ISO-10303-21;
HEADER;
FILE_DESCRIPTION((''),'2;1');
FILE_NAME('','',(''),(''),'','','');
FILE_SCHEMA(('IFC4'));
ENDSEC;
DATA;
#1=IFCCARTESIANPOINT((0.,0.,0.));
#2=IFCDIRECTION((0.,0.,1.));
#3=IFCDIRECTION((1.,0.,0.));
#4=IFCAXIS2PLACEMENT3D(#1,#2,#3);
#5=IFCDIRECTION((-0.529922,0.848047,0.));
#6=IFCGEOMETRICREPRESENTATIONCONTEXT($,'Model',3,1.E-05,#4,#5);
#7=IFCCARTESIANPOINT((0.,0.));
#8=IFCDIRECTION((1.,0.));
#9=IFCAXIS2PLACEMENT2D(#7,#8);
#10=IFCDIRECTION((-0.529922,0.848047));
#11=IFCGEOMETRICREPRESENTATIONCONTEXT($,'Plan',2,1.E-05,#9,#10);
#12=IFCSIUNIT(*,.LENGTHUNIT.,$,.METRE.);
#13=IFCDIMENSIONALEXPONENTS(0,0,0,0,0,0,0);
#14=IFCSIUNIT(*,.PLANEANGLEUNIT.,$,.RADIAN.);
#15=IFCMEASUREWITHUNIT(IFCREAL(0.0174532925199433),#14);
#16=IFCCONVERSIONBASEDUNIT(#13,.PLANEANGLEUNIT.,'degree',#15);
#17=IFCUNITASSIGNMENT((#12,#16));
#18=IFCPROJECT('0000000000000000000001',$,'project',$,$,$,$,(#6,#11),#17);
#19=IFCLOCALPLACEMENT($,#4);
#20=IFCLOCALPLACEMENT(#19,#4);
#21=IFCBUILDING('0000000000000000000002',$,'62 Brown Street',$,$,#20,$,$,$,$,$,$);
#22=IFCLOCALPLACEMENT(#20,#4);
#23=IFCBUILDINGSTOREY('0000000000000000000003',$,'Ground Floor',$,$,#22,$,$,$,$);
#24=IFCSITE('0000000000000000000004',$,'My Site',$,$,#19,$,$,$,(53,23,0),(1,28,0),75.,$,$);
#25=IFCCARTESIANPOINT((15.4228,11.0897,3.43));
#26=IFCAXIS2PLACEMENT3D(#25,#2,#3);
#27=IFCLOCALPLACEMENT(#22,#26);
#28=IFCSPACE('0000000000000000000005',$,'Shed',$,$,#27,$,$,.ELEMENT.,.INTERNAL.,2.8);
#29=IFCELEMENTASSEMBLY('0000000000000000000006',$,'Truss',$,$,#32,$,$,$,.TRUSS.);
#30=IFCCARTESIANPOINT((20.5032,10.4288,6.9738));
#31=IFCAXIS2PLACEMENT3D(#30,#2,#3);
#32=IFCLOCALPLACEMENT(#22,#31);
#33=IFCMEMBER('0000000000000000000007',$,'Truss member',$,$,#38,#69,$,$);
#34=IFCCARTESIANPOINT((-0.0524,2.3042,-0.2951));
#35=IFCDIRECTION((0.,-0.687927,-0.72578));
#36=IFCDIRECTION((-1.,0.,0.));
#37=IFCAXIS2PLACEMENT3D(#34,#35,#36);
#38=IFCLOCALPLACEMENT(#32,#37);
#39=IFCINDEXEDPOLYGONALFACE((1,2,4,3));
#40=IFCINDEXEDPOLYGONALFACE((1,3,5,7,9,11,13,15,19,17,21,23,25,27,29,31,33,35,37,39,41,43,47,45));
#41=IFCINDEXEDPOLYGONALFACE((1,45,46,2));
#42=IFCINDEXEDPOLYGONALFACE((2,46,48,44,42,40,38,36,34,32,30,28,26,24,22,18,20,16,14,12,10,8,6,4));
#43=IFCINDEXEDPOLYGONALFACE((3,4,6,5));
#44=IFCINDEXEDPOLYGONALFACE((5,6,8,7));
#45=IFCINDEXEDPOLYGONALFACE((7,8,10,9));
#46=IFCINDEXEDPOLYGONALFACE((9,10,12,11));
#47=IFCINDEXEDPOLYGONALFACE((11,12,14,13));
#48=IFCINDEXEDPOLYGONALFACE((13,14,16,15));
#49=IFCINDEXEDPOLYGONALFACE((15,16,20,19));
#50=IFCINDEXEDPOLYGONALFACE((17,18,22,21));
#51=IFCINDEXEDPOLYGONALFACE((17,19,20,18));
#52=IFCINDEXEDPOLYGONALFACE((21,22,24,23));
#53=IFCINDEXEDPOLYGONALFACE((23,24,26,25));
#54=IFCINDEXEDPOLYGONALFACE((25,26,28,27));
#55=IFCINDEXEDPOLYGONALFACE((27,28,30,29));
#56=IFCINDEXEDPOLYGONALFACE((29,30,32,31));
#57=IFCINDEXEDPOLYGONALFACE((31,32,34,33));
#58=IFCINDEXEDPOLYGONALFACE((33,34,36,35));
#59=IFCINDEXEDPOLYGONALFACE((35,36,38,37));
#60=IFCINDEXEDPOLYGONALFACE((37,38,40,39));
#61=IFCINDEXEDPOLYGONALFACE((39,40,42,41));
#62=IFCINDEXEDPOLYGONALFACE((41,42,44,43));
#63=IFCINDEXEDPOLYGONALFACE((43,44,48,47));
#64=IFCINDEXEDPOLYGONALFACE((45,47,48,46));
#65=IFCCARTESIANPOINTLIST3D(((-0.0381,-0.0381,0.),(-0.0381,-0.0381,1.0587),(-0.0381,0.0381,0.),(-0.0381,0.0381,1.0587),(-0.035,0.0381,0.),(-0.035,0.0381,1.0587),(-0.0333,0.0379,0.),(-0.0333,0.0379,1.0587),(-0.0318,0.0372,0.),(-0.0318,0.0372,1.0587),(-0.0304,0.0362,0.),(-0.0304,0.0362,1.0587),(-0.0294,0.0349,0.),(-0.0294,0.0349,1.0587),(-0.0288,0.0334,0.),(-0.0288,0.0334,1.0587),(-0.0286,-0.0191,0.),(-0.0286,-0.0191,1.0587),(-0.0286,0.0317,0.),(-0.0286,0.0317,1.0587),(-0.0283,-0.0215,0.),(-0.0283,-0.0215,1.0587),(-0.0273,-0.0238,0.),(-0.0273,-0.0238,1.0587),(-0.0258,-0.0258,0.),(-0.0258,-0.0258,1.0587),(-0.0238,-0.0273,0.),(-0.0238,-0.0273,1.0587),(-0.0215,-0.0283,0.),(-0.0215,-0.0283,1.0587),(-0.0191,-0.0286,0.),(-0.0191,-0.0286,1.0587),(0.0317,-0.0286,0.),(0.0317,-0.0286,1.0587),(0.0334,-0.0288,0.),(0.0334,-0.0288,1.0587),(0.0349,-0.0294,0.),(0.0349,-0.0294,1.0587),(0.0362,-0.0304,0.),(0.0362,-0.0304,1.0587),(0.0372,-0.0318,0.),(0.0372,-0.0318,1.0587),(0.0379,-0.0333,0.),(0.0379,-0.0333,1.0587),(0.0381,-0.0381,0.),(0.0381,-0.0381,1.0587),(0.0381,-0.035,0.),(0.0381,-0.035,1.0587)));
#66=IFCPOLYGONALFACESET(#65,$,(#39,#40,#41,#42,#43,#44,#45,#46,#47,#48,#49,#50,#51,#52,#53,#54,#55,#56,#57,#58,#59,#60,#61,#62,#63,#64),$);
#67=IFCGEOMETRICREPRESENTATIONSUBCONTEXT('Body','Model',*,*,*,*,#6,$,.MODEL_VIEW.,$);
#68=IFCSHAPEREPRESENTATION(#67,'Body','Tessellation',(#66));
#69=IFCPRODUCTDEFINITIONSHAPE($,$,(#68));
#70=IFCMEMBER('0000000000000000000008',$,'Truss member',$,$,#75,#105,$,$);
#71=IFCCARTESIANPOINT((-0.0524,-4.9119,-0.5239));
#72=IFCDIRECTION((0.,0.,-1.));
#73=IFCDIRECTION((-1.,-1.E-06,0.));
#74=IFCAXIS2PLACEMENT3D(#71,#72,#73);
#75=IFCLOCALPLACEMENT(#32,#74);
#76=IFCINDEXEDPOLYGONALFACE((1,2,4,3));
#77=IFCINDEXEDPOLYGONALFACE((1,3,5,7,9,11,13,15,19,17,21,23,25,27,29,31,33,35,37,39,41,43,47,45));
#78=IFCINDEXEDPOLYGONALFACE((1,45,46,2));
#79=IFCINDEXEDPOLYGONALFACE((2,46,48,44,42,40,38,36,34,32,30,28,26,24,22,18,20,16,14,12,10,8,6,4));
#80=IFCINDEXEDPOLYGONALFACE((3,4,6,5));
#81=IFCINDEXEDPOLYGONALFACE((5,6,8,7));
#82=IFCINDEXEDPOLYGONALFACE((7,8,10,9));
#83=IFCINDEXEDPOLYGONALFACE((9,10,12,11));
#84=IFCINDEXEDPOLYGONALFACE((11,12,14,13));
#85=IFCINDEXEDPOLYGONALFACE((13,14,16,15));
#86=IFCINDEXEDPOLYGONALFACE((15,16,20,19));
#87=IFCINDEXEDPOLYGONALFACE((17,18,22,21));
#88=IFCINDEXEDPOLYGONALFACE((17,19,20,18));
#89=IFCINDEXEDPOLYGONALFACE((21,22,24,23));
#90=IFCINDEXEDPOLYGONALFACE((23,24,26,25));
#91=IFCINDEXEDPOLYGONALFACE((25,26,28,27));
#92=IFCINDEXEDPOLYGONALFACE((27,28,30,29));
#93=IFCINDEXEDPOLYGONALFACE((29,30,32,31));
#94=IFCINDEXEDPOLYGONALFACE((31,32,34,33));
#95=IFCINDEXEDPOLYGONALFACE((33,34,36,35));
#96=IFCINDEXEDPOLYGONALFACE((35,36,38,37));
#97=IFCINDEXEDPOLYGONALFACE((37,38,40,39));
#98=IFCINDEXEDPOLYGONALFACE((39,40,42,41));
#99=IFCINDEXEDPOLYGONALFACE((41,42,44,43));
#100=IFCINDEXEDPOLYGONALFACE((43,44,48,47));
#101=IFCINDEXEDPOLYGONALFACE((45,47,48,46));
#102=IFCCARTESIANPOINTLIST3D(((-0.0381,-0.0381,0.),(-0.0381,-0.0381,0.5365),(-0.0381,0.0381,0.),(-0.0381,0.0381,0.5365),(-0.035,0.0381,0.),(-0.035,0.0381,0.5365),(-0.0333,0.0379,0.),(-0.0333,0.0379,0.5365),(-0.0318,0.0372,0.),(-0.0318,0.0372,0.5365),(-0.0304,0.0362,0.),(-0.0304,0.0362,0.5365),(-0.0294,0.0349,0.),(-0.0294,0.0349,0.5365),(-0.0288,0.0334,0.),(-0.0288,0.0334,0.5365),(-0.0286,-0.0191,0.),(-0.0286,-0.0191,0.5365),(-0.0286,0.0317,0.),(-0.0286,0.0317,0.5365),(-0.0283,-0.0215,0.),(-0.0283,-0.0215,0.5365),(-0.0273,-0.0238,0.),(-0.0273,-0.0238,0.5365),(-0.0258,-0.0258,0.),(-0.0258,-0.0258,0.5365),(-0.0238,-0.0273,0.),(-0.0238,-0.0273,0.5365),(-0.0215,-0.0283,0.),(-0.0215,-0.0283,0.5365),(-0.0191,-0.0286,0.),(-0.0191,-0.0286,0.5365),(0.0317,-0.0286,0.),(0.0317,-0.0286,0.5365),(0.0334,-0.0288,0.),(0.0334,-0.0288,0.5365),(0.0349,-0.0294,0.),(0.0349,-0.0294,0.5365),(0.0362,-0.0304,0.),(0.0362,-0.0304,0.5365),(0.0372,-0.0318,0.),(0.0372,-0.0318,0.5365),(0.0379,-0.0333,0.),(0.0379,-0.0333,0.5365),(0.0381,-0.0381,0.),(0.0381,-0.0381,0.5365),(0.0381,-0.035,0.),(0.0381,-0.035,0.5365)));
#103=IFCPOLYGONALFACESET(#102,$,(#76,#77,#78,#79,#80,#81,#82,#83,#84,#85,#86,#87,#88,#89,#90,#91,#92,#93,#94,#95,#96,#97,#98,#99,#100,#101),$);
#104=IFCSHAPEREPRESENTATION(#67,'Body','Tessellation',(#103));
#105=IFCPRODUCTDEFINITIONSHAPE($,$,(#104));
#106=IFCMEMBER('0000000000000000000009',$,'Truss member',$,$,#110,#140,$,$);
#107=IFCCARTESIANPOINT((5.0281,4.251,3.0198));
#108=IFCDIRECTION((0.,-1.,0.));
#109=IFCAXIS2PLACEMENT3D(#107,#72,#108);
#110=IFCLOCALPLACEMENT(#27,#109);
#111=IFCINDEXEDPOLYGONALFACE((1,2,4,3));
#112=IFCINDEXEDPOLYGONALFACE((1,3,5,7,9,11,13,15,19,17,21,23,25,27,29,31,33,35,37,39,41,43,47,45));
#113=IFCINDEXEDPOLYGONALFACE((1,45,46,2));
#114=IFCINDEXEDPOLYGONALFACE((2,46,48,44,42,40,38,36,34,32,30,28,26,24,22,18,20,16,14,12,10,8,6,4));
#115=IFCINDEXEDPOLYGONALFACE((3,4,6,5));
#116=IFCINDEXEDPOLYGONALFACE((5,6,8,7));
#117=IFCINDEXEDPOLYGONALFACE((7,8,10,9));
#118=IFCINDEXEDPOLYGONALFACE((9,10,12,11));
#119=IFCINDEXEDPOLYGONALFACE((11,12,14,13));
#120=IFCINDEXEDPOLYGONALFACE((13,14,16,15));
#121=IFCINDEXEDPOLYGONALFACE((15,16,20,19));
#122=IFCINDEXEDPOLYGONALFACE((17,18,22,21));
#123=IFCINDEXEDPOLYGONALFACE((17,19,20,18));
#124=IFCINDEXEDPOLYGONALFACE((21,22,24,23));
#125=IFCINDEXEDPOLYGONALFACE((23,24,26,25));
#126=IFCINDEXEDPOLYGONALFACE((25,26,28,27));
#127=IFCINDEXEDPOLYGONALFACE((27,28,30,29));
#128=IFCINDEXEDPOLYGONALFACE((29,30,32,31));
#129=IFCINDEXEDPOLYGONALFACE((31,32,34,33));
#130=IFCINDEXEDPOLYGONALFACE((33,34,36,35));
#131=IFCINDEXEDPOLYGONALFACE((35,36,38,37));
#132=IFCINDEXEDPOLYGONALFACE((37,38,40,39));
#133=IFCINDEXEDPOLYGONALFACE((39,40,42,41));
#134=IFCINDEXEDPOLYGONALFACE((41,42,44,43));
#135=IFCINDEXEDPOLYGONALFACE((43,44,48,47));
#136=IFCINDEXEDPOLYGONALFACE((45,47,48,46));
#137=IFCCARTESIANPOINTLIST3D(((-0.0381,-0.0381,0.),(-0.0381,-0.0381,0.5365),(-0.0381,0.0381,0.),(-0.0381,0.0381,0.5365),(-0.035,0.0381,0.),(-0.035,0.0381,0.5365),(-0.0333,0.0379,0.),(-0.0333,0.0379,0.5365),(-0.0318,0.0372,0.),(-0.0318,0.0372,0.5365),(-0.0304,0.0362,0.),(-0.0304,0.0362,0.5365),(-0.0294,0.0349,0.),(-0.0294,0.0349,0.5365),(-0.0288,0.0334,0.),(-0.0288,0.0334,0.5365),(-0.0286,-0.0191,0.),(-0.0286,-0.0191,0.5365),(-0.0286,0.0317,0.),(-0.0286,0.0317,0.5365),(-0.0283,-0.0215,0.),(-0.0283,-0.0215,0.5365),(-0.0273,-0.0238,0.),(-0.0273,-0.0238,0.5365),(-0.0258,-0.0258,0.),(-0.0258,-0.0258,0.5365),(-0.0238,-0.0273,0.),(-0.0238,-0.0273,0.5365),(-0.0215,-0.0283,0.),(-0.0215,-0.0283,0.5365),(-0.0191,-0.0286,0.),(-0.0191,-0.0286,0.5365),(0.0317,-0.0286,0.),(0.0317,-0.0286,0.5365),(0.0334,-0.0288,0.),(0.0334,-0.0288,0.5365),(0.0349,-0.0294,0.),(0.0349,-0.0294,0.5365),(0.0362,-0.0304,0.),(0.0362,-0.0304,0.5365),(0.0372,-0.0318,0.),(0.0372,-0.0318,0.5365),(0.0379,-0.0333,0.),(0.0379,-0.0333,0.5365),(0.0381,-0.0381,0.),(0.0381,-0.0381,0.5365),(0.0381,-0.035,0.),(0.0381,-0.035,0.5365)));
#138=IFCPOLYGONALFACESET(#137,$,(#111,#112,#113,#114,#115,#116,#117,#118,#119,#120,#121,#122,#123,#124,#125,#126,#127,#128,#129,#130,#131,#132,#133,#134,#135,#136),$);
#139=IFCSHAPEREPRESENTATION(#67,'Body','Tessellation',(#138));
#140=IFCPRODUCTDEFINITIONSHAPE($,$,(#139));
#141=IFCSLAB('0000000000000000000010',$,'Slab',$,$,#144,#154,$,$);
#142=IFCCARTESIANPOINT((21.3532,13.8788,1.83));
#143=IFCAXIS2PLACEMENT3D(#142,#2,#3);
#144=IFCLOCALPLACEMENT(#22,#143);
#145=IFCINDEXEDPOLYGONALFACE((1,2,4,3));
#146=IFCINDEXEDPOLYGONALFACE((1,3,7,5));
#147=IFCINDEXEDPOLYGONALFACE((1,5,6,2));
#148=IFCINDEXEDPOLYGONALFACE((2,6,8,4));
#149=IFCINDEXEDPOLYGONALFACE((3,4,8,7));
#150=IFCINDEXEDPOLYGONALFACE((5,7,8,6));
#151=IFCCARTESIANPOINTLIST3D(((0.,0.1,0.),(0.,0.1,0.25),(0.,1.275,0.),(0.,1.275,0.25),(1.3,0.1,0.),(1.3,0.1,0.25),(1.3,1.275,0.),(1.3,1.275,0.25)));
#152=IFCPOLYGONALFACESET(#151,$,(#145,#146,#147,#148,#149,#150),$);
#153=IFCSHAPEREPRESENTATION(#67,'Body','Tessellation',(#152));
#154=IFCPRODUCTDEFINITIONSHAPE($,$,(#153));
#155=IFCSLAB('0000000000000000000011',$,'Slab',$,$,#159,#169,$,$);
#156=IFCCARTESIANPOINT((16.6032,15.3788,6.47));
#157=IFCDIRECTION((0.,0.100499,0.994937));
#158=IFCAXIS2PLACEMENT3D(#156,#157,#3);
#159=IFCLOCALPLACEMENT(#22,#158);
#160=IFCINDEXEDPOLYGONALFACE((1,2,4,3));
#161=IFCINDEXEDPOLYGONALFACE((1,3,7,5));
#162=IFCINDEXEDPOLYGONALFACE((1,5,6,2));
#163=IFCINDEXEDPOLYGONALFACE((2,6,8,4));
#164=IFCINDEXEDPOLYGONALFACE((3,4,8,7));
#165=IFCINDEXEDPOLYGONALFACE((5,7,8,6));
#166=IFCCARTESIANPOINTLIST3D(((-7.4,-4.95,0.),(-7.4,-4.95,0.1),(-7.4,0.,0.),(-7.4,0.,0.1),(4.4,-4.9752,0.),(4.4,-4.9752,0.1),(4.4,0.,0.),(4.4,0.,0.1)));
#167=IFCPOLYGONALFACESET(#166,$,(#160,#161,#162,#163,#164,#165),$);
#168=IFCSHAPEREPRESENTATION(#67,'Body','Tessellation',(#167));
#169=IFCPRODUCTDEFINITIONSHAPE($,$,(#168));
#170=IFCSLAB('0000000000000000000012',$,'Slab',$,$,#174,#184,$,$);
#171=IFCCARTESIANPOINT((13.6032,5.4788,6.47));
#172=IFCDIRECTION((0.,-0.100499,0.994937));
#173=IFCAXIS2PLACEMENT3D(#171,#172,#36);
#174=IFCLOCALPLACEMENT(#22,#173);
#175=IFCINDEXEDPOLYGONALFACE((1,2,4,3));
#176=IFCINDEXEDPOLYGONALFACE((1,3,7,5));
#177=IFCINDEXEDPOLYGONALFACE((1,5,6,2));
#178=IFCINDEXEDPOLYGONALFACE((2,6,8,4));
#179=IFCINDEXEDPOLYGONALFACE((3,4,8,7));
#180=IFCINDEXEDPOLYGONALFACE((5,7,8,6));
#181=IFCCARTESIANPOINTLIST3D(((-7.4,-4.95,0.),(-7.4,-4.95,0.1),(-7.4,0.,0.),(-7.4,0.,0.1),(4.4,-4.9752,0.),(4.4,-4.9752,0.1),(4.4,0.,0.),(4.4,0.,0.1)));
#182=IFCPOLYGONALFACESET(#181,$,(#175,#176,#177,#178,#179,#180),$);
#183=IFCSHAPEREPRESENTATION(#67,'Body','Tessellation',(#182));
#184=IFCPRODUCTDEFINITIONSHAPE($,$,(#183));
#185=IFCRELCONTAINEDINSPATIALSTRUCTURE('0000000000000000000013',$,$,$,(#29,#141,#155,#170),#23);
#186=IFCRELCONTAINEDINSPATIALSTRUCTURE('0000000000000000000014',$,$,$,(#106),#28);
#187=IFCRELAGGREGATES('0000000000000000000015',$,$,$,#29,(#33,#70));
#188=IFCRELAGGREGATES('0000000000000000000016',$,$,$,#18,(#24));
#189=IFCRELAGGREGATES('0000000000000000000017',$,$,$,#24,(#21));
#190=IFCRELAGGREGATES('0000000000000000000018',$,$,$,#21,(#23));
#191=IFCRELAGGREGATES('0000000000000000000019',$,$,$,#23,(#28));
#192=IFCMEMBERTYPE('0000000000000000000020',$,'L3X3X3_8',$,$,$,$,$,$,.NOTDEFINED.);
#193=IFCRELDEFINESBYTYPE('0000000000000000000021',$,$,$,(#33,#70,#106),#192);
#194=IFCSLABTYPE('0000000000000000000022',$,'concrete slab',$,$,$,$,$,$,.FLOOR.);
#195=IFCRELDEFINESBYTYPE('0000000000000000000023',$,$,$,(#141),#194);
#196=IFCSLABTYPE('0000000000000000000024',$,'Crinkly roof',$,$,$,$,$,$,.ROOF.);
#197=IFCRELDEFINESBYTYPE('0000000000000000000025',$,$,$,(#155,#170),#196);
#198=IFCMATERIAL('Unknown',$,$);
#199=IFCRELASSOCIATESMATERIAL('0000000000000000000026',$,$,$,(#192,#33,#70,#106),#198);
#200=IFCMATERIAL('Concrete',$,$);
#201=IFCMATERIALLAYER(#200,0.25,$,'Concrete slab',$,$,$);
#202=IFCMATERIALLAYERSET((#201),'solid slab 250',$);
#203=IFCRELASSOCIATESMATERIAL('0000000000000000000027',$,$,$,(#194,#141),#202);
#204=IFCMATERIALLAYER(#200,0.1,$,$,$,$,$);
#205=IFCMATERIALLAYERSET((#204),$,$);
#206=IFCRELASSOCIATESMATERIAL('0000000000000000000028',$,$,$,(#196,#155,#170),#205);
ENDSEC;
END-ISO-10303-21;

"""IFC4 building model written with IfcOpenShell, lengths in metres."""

from ifc_helpers import new_model, entity, si_unit, converted_unit, direction, frame, origin_with_axes, origin_2d_with_axis, place, context, subcontext, project, spatial, indexed_curve, l_section, outline, extrude, material, layer, layer_set, layer_usage, material_profile, profile_set, profile_usage, type_object, element, aggregate, save


model = new_model("IFC4")

# Units and contexts
model_context = context("Model", 3, precision=1e-05, world=origin_with_axes(), true_north=direction((-0.529922, 0.848047, 0.0)))
plan_context = context("Plan", 2, precision=1e-05, world=origin_2d_with_axis(), true_north=direction((-0.529922, 0.848047)))
body_context_1 = subcontext(model_context, "Body", "Model", "MODEL_VIEW")
ifc_project = project(units=[si_unit("LENGTHUNIT", "METRE"), converted_unit("PLANEANGLEUNIT", "degree", entity("IfcReal", 0.0174532925199433), si_unit("PLANEANGLEUNIT", "RADIAN"), dimensions=[0, 0, 0, 0, 0, 0, 0])], contexts=[model_context, plan_context])

# Site, building, storey
site_placement = place(None, origin_with_axes())
site = spatial("IfcSite", under=ifc_project, at=site_placement, Name="My Site", RefLatitude=(53, 23, 0), RefLongitude=(1, 28, 0), RefElevation=75.0)
building_placement = place(site_placement, origin_with_axes())
building = spatial("IfcBuilding", under=site, at=building_placement, Name="62 Brown Street")
storey_placement = place(building_placement, origin_with_axes())
storey = spatial("IfcBuildingStorey", under=building, at=storey_placement, Name="Ground Floor")

# Shared definitions
ifc_material_1 = material(Name="Concrete")

# Element assembly, members
assembly_placement = place(storey_placement, frame((20.5032, 10.4288, 6.9738), z_axis=(0.0, 0.0, 1.0), x_axis=(1.0, 0.0, 0.0)))
assembly = element("IfcElementAssembly", 1, at=assembly_placement, inside=storey, Name="Truss", PredefinedType="TRUSS")
ifc_material_2 = material(Name="Unknown")
ifc_material_profile_1 = material_profile(ifc_material_2, l_section(Depth=0.0762, Width=0.0762, Thickness=0.0095, FilletRadius=0.0095, EdgeRadius=0.0064))
ifc_profile_set_1 = profile_set([ifc_material_profile_1])
member_type_1 = type_object("IfcMemberType", Name="L3X3X3_8", PredefinedType="NOTDEFINED", material=ifc_profile_set_1)
ifc_profile_usage_1 = profile_usage(ifc_profile_set_1, cardinal=5)
member_1_placement = place(assembly_placement, frame((-0.0524, 2.3042, -0.2951), z_axis=(0.0, -0.687927, -0.72578), x_axis=(-1.0, 0.0, 0.0)))
member_1 = element("IfcMember", 2, at=member_1_placement, type_object=member_type_1, material=ifc_profile_usage_1, Name="Truss member", context=body_context_1, shape_type="SweptSolid", body=[
    extrude(l_section(Depth=0.0762, Width=0.0762, Thickness=0.0095, FilletRadius=0.0095, EdgeRadius=0.0064), origin_with_axes(), (0.0, 0.0, 1.0), 1.0587),
])
ifc_profile_usage_2 = profile_usage(ifc_profile_set_1, cardinal=5)
member_2_placement = place(assembly_placement, frame((-0.0524, -4.9119, -0.5239), z_axis=(0.0, 0.0, -1.0), x_axis=(-1.0, -0.000001, 0.0)))
member_2 = element("IfcMember", 3, at=member_2_placement, type_object=member_type_1, material=ifc_profile_usage_2, Name="Truss member", context=body_context_1, shape_type="SweptSolid", body=[
    extrude(l_section(Depth=0.0762, Width=0.0762, Thickness=0.0095, FilletRadius=0.0095, EdgeRadius=0.0064), origin_with_axes(), (0.0, 0.0, 1.0), 0.5365),
])

# Shared definitions
space_1_placement = place(storey_placement, frame((15.4228, 11.0897, 3.43), z_axis=(0.0, 0.0, 1.0), x_axis=(1.0, 0.0, 0.0)))
space_1 = spatial("IfcSpace", under=storey, at=space_1_placement, Name="Shed", CompositionType="ELEMENT", PredefinedType="INTERNAL", ElevationWithFlooring=2.8)

# Member
ifc_profile_usage_3 = profile_usage(ifc_profile_set_1, cardinal=5)
member_3_placement = place(space_1_placement, frame((5.0281, 4.251, 3.0198), z_axis=(0.0, 0.0, -1.0), x_axis=(0.0, -1.0, 0.0)))
element("IfcMember", 4, at=member_3_placement, inside=space_1, type_object=member_type_1, material=ifc_profile_usage_3, Name="Truss member", context=body_context_1, shape_type="SweptSolid", body=[
    extrude(l_section(Depth=0.0762, Width=0.0762, Thickness=0.0095, FilletRadius=0.0095, EdgeRadius=0.0064), origin_with_axes(), (0.0, 0.0, 1.0), 0.5365),
])
aggregate(assembly, [member_1, member_2])

# Slabs
ifc_layer_1 = layer(ifc_material_1, 0.25, Name="Concrete slab")
ifc_layer_set_1 = layer_set([ifc_layer_1], Name="solid slab 250")
ifc_layer_usage_1 = layer_usage(ifc_layer_set_1, "AXIS3", "POSITIVE", 0.0)
slab_type_1 = type_object("IfcSlabType", Name="concrete slab", PredefinedType="FLOOR", material=ifc_layer_set_1)
slab_1_placement = place(storey_placement, frame((21.3532, 13.8788, 1.83), z_axis=(0.0, 0.0, 1.0), x_axis=(1.0, 0.0, 0.0)))
element("IfcSlab", 5, at=slab_1_placement, inside=storey, type_object=slab_type_1, material=ifc_layer_usage_1, Name="Slab", context=body_context_1, shape_type="SweptSolid", body=[
    extrude(outline(indexed_curve([(0.0, 0.1), (1.3, 0.1), (1.3, 1.275), (0.0, 1.275), (0.0, 0.1)])), None, (0.0, 0.0, 1.0), 0.25),
])
ifc_layer_2 = layer(ifc_material_1, 0.1)
ifc_layer_set_2 = layer_set([ifc_layer_2])
ifc_layer_usage_2 = layer_usage(ifc_layer_set_2, "AXIS3", "POSITIVE", 0.0)
slab_type_2 = type_object("IfcSlabType", Name="Crinkly roof", PredefinedType="ROOF", material=ifc_layer_set_2)
slab_2_placement = place(storey_placement, frame((16.6032, 15.3788, 6.47), z_axis=(0.0, 0.100499, 0.994937), x_axis=(1.0, 0.0, 0.0)))
element("IfcSlab", 6, at=slab_2_placement, inside=storey, type_object=slab_type_2, material=ifc_layer_usage_2, Name="Slab", context=body_context_1, shape_type="SweptSolid", body=[
    extrude(outline(indexed_curve([(4.4, 0.0), (-7.4, 0.0), (-7.4, -4.95), (4.4, -4.9752), (4.4, 0.0)])), None, (0.0, 0.0, 1.0), 0.1),
])
ifc_layer_usage_3 = layer_usage(ifc_layer_set_2, "AXIS3", "POSITIVE", 0.0)
slab_3_placement = place(storey_placement, frame((13.6032, 5.4788, 6.47), z_axis=(0.0, -0.100499, 0.994937), x_axis=(-1.0, 0.0, 0.0)))
element("IfcSlab", 7, at=slab_3_placement, inside=storey, type_object=slab_type_2, material=ifc_layer_usage_3, Name="Slab", context=body_context_1, shape_type="SweptSolid", body=[
    extrude(outline(indexed_curve([(4.4, 0.0), (-7.4, 0.0), (-7.4, -4.95), (4.4, -4.9752), (4.4, 0.0)])), None, (0.0, 0.0, 1.0), 0.1),
])

save(model, "model.ifc")
